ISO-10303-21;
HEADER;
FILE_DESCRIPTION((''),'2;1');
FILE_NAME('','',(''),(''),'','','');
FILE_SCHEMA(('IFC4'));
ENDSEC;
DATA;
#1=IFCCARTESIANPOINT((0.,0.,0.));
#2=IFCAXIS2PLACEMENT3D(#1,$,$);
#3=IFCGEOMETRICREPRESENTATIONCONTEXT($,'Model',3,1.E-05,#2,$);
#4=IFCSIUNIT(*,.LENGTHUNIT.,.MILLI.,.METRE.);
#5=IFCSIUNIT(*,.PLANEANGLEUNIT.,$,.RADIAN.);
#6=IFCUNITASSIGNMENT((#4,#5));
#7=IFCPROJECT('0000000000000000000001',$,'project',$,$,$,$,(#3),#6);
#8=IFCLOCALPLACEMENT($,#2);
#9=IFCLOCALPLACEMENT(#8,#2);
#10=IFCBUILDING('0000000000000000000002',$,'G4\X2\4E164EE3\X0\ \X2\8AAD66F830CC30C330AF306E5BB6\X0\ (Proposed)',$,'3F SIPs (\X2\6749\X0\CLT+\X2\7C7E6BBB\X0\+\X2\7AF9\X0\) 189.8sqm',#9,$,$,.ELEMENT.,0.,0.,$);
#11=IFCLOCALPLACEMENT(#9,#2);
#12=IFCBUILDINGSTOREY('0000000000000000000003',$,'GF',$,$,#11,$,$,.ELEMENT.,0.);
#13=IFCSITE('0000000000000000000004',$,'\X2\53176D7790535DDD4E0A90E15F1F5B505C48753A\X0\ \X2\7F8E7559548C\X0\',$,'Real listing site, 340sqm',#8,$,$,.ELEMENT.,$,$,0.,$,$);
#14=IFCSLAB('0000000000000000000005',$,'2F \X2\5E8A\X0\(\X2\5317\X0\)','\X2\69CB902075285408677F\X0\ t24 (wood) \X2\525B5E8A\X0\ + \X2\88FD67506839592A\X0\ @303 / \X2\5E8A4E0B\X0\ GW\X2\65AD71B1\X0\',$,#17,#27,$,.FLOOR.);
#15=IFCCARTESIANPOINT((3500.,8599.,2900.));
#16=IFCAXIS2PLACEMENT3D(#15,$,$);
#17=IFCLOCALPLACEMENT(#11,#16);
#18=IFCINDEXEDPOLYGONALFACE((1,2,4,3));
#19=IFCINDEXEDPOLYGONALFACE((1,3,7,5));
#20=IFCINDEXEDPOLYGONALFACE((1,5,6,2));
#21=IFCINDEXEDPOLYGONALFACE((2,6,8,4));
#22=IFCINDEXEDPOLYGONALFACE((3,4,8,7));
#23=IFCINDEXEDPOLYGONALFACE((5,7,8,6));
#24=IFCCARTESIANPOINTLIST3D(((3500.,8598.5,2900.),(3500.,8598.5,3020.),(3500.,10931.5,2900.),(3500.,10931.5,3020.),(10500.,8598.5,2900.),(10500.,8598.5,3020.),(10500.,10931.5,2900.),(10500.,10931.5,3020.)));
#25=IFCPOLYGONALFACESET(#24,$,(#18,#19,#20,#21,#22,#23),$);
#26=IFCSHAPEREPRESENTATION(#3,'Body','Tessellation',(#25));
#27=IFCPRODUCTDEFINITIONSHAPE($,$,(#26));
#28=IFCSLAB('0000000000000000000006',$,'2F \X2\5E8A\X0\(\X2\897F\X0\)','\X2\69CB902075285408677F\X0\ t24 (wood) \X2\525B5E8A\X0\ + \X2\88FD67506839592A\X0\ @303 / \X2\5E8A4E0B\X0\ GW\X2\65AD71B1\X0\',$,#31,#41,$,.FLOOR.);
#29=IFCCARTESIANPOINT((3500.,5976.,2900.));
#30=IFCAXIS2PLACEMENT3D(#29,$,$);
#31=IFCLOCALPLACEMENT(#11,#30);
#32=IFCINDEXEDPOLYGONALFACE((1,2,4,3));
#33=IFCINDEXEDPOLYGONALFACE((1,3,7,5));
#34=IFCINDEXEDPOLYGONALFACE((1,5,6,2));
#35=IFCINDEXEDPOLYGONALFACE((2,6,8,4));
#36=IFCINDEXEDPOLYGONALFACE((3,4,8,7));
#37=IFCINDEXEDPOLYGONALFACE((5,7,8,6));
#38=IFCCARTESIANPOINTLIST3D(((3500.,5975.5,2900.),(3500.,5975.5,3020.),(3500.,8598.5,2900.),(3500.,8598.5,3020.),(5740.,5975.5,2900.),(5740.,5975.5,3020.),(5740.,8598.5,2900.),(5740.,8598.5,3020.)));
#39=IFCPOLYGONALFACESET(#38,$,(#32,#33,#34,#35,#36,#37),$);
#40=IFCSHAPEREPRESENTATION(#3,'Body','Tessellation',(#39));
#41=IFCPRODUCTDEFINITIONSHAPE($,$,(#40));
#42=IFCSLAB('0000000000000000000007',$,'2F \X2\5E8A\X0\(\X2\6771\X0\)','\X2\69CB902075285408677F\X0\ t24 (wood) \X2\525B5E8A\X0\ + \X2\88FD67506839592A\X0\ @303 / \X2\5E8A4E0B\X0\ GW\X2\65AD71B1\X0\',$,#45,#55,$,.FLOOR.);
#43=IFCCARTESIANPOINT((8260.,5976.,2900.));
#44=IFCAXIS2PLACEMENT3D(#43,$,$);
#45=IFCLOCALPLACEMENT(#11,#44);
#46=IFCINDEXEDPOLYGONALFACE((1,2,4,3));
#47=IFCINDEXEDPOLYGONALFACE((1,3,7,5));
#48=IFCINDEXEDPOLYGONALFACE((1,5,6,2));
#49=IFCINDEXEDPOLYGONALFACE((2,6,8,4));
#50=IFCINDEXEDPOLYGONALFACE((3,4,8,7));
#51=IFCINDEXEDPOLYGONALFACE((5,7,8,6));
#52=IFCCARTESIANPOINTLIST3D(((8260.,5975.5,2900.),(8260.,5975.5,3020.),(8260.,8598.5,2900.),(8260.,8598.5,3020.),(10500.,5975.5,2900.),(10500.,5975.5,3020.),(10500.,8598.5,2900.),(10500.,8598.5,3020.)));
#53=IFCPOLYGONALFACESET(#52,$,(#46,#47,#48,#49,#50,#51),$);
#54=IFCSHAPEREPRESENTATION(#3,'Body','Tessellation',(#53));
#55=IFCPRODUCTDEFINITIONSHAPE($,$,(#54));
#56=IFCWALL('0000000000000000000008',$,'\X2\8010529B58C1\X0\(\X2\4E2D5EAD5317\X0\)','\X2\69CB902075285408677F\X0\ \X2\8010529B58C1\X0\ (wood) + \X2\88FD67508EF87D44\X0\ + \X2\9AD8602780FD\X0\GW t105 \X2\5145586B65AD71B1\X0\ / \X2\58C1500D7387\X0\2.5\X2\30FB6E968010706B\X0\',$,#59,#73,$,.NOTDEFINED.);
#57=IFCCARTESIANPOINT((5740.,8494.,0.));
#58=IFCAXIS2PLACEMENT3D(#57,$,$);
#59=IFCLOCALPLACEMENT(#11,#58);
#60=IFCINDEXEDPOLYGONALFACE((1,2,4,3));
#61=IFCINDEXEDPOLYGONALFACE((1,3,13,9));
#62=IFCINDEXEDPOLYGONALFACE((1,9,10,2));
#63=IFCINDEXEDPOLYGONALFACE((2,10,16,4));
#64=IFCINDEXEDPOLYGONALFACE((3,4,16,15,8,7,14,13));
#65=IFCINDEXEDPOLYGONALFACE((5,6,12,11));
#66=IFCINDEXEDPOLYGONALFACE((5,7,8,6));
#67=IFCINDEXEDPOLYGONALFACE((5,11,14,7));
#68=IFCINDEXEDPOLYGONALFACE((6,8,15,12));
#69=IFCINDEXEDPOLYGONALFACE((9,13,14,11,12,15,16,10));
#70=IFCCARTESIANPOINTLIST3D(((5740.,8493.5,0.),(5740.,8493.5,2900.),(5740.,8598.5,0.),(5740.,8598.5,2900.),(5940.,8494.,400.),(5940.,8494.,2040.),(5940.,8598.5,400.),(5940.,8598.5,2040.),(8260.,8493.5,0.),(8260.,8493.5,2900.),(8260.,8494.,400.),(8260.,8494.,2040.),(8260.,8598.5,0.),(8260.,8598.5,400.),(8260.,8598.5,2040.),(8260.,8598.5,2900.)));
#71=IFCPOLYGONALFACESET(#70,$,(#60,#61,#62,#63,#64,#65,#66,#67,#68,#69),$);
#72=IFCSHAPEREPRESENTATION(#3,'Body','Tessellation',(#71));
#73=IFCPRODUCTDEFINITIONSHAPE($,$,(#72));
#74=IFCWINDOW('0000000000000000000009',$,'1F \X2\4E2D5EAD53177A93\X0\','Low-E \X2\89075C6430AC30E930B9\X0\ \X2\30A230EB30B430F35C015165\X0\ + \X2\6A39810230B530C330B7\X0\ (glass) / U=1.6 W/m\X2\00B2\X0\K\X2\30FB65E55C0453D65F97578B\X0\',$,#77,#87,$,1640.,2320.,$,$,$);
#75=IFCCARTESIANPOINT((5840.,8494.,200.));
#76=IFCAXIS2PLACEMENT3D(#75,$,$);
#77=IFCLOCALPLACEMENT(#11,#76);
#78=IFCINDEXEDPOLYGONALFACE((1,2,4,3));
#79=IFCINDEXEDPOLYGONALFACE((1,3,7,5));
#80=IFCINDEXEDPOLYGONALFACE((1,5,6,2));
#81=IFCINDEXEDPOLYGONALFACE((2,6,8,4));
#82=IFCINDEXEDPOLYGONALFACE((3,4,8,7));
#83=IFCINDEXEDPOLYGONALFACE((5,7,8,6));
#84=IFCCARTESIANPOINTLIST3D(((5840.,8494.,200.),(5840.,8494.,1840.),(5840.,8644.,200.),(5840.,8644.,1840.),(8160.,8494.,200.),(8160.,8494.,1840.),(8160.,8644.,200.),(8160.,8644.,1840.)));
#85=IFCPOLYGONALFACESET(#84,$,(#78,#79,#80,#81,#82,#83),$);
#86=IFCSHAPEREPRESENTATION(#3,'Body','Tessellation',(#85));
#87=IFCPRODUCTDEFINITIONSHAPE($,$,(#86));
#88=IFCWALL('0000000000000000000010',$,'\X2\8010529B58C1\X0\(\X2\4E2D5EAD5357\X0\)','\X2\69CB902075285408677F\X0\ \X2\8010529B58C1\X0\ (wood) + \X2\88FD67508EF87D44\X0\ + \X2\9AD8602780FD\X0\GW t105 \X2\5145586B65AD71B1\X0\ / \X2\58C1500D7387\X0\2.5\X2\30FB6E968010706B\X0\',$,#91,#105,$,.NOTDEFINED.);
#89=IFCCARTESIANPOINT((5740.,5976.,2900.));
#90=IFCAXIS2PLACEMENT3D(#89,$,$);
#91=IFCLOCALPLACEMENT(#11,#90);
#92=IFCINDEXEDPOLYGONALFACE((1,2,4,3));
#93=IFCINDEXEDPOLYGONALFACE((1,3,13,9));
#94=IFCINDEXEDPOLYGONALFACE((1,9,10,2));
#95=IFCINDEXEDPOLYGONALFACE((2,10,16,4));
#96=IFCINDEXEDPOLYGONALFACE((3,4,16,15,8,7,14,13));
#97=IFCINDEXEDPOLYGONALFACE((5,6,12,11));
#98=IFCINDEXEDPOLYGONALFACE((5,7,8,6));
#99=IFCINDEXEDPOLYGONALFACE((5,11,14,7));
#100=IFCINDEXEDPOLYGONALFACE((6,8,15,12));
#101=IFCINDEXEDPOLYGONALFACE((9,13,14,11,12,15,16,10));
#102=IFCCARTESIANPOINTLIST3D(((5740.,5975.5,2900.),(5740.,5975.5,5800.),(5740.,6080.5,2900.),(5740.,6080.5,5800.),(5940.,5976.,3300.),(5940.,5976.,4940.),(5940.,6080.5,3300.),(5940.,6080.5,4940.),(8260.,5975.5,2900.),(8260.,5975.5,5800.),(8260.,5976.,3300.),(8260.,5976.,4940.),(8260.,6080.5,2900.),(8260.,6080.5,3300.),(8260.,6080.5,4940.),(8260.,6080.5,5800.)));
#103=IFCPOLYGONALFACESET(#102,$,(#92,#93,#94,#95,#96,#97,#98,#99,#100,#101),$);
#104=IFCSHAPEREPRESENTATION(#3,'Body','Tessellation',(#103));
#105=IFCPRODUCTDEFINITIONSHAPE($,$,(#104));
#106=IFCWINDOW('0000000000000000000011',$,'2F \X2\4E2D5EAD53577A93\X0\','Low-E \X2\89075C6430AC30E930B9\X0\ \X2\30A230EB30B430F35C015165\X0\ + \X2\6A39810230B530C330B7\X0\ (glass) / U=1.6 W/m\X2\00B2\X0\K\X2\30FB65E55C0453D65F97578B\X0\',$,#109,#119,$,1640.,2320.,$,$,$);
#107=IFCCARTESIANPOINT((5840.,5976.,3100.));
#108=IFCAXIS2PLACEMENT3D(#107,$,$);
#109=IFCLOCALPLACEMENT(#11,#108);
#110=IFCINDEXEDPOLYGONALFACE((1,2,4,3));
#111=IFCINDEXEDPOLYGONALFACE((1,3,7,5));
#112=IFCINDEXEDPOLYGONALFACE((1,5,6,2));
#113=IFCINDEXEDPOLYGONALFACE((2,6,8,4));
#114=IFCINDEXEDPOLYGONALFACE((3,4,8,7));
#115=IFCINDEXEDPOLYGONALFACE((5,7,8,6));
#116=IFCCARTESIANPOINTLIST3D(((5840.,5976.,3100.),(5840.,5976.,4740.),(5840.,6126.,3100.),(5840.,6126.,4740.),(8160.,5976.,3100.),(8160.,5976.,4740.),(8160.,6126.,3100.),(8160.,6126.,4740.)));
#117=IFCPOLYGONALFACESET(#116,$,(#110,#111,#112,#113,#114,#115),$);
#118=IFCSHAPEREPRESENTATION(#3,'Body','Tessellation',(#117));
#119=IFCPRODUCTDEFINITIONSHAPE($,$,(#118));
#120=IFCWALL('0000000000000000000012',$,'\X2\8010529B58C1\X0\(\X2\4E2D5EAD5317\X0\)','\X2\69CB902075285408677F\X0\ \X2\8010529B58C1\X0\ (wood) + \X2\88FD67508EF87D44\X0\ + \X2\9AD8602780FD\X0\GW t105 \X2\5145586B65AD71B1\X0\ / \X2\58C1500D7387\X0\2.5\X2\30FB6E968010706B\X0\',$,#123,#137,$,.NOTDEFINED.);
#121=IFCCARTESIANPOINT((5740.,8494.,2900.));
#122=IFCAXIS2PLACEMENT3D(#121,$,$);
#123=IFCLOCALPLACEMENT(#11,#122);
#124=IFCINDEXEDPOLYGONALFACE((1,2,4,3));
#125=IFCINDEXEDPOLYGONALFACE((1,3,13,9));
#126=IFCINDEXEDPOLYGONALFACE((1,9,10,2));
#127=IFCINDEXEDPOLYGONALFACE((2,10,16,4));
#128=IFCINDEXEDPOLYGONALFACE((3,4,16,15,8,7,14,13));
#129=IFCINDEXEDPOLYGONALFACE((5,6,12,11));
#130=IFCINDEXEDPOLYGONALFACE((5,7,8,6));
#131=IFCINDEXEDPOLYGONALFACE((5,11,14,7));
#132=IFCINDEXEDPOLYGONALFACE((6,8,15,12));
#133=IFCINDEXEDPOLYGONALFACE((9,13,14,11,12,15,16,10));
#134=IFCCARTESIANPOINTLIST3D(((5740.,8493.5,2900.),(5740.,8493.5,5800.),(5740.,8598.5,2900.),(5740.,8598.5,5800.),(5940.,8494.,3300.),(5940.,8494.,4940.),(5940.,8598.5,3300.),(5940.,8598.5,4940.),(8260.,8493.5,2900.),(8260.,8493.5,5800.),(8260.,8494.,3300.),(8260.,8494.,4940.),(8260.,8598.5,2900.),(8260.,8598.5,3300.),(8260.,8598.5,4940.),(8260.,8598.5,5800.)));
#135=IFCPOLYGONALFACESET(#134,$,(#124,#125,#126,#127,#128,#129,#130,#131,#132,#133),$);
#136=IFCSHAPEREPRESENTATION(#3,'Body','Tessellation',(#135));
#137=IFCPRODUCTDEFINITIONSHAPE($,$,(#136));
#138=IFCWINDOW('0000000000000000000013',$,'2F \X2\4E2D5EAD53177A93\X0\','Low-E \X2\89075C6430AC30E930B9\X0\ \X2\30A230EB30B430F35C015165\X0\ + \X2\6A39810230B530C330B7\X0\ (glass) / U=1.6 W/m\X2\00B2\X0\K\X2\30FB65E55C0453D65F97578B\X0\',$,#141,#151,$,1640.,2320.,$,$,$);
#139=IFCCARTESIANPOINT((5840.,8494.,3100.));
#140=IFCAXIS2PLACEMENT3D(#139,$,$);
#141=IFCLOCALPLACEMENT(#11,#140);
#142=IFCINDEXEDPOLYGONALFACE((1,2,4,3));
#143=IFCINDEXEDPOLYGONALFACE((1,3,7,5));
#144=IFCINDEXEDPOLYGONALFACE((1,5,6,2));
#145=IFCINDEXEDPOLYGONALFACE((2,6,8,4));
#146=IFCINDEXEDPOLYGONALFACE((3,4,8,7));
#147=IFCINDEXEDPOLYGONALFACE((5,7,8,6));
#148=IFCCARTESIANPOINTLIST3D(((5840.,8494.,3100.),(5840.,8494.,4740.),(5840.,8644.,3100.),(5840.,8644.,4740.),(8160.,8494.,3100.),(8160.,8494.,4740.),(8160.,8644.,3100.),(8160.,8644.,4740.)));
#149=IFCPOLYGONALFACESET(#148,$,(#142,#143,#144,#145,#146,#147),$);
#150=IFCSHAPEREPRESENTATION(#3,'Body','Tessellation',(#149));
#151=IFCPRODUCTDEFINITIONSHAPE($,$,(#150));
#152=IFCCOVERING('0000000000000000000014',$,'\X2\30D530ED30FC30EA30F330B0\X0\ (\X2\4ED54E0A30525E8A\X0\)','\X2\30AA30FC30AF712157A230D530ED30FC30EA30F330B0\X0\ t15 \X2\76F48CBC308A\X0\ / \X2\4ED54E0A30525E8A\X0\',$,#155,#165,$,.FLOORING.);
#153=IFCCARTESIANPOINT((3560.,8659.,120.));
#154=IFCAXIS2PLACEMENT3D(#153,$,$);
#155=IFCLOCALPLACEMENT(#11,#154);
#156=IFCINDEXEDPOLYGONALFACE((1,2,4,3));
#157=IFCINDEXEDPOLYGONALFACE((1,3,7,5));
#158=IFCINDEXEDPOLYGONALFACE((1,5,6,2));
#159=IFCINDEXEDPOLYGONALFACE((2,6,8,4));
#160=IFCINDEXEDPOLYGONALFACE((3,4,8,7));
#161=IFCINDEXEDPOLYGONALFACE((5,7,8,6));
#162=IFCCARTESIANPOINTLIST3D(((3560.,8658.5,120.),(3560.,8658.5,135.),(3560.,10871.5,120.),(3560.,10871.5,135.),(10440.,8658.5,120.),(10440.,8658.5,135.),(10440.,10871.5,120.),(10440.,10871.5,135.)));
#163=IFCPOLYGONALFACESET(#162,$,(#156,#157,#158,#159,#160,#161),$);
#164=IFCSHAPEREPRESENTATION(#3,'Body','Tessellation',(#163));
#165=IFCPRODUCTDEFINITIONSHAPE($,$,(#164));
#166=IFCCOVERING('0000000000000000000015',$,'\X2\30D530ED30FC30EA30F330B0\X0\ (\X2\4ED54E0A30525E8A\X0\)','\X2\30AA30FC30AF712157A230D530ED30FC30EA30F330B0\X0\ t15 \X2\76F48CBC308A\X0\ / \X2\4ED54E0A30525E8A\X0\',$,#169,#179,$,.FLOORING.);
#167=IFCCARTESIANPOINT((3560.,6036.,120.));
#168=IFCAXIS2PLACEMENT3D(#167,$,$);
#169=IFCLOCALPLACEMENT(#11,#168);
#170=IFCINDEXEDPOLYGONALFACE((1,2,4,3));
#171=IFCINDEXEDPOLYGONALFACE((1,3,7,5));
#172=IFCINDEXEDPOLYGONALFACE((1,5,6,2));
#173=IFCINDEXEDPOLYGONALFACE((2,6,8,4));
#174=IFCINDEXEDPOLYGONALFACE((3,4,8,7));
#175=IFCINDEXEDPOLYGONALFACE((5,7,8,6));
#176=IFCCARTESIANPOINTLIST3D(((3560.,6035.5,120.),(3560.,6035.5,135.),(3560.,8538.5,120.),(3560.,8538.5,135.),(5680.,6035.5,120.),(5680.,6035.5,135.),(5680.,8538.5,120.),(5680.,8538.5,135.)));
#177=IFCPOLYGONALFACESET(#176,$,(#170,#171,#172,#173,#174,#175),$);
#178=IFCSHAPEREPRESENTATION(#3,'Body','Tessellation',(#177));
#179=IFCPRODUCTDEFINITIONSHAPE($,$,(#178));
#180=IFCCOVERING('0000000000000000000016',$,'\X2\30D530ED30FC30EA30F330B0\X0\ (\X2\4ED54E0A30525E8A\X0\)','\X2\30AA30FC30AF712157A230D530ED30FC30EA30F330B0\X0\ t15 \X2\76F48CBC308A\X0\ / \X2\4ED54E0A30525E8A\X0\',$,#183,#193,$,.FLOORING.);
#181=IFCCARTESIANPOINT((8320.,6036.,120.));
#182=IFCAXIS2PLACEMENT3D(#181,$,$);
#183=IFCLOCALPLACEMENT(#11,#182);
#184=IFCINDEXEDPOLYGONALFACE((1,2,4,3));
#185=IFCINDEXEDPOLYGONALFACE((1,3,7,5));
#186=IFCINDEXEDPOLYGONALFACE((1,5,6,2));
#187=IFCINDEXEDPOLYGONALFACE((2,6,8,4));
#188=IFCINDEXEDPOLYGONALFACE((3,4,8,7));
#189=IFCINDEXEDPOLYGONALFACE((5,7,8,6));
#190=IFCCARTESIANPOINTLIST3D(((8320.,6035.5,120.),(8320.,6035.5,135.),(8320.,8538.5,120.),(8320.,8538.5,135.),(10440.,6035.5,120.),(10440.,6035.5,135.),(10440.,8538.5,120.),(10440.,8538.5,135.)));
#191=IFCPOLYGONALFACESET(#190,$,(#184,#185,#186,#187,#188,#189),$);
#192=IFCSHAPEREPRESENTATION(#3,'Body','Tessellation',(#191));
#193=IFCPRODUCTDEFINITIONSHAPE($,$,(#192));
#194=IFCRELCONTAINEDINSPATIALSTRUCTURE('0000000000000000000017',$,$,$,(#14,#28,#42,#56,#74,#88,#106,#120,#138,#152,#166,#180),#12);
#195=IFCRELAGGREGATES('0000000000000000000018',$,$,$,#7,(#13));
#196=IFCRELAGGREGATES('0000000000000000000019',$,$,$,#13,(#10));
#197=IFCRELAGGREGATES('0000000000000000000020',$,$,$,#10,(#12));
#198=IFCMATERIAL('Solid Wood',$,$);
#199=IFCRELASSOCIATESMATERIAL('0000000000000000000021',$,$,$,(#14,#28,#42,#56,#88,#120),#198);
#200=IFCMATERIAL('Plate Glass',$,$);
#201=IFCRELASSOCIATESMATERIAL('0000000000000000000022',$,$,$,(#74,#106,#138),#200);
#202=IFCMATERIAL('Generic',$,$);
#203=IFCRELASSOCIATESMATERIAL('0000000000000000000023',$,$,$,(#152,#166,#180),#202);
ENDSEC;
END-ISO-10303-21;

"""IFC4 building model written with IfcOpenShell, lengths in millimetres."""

from ifc_helpers import new_model, si_unit, frame, frame_2d, origin, place, context, project, spatial, rectangle, extrude, material, element, fill, save


model = new_model("IFC4")

# Units and contexts
model_context = context("Model", 3, precision=1e-05, world=origin())
ifc_project = project(units=[si_unit("LENGTHUNIT", "METRE", prefix="MILLI"), si_unit("PLANEANGLEUNIT", "RADIAN")], contexts=[model_context])

# Site, building, storey
site_placement = place(None, origin())
site = spatial("IfcSite", under=ifc_project, at=site_placement, Name="北海道川上郡弟子屈町 美留和", ObjectType="Real listing site, 340sqm", CompositionType="ELEMENT", RefElevation=0.0)
building_placement = place(site_placement, origin())
building = spatial("IfcBuilding", under=site, at=building_placement, Name="G4世代 読書ヌックの家 (Proposed)", ObjectType="3F SIPs (杉CLT+籾殻+竹) 189.8sqm", CompositionType="ELEMENT", ElevationOfRefHeight=0.0, ElevationOfTerrain=0.0)
storey_placement = place(building_placement, origin())
storey = spatial("IfcBuildingStorey", under=building, at=storey_placement, Name="GF", CompositionType="ELEMENT", Elevation=0.0)

# Slabs
ifc_material_1 = material(Name="Solid Wood")
slab_1_placement = place(storey_placement, frame((3500.0, 8599.0, 2900.0)))
element("IfcSlab", 1, at=slab_1_placement, inside=storey, material=ifc_material_1, Name="2F 床(北)", Description="構造用合板 t24 (wood) 剛床 + 製材根太 @303 / 床下 GW断熱", PredefinedType="FLOOR", context=model_context, shape_type="SweptSolid", body=[
    extrude(rectangle(XDim=7000.0, YDim=2333.0, at=frame_2d((3500.0, 1166.0))), frame((3500.0, 8599.0, 2900.0)), (0.0, 0.0, 1.0), 120.0),
])
slab_2_placement = place(storey_placement, frame((3500.0, 5976.0, 2900.0)))
element("IfcSlab", 2, at=slab_2_placement, inside=storey, material=ifc_material_1, Name="2F 床(西)", Description="構造用合板 t24 (wood) 剛床 + 製材根太 @303 / 床下 GW断熱", PredefinedType="FLOOR", context=model_context, shape_type="SweptSolid", body=[
    extrude(rectangle(XDim=2240.0, YDim=2623.0, at=frame_2d((1120.0, 1311.0))), frame((3500.0, 5976.0, 2900.0)), (0.0, 0.0, 1.0), 120.0),
])
slab_3_placement = place(storey_placement, frame((8260.0, 5976.0, 2900.0)))
element("IfcSlab", 3, at=slab_3_placement, inside=storey, material=ifc_material_1, Name="2F 床(東)", Description="構造用合板 t24 (wood) 剛床 + 製材根太 @303 / 床下 GW断熱", PredefinedType="FLOOR", context=model_context, shape_type="SweptSolid", body=[
    extrude(rectangle(XDim=2240.0, YDim=2623.0, at=frame_2d((1120.0, 1311.0))), frame((8260.0, 5976.0, 2900.0)), (0.0, 0.0, 1.0), 120.0),
])

# Wall, opening, window
wall_1_placement = place(storey_placement, frame((5740.0, 8494.0, 0.0)))
wall_1 = element("IfcWall", 4, at=wall_1_placement, inside=storey, material=ifc_material_1, Name="耐力壁(中庭北)", Description="構造用合板 耐力壁 (wood) + 製材軸組 + 高性能GW t105 充填断熱 / 壁倍率2.5・準耐火", PredefinedType="NOTDEFINED", context=model_context, shape_type="SweptSolid", body=[
    extrude(rectangle(XDim=2520.0, YDim=105.0, at=frame_2d((1260.0, 52.0))), frame((5740.0, 8494.0, 0.0)), (0.0, 0.0, 1.0), 2900.0),
])
opening_1_placement = place(storey_placement, frame((5840.0, 8494.0, 200.0)))
opening_1 = element("IfcOpeningElement", 5, at=opening_1_placement, cuts=wall_1, PredefinedType="NOTDEFINED", context=model_context, shape_type="SweptSolid", body=[
    extrude(rectangle(XDim=2320.0, YDim=150.0, at=frame_2d((1160.0, 75.0))), frame((5840.0, 8494.0, 200.0)), (0.0, 0.0, 1.0), 1640.0),
])
ifc_material_2 = material(Name="Plate Glass")
window_1_placement = place(storey_placement, frame((5840.0, 8494.0, 200.0)))
window_1 = element("IfcWindow", 6, at=window_1_placement, inside=storey, material=ifc_material_2, Name="1F 中庭北窓", Description="Low-E 複層ガラス アルゴン封入 + 樹脂サッシ (glass) / U=1.6 W/m²K・日射取得型", OverallHeight=1640.0, OverallWidth=2320.0, context=model_context, shape_type="SweptSolid", body=[
    extrude(rectangle(XDim=2320.0, YDim=150.0, at=frame_2d((1160.0, 75.0))), frame((5840.0, 8494.0, 200.0)), (0.0, 0.0, 1.0), 1640.0),
])
fill(opening_1, window_1)

# Walls, openings, windows
wall_2_placement = place(storey_placement, frame((5740.0, 5976.0, 2900.0)))
wall_2 = element("IfcWall", 7, at=wall_2_placement, inside=storey, material=ifc_material_1, Name="耐力壁(中庭南)", Description="構造用合板 耐力壁 (wood) + 製材軸組 + 高性能GW t105 充填断熱 / 壁倍率2.5・準耐火", PredefinedType="NOTDEFINED", context=model_context, shape_type="SweptSolid", body=[
    extrude(rectangle(XDim=2520.0, YDim=105.0, at=frame_2d((1260.0, 52.0))), frame((5740.0, 5976.0, 2900.0)), (0.0, 0.0, 1.0), 2900.0),
])
opening_2_placement = place(storey_placement, frame((5840.0, 5976.0, 3100.0)))
opening_2 = element("IfcOpeningElement", 8, at=opening_2_placement, cuts=wall_2, PredefinedType="NOTDEFINED", context=model_context, shape_type="SweptSolid", body=[
    extrude(rectangle(XDim=2320.0, YDim=150.0, at=frame_2d((1160.0, 75.0))), frame((5840.0, 5976.0, 3100.0)), (0.0, 0.0, 1.0), 1640.0),
])
window_2_placement = place(storey_placement, frame((5840.0, 5976.0, 3100.0)))
window_2 = element("IfcWindow", 9, at=window_2_placement, inside=storey, material=ifc_material_2, Name="2F 中庭南窓", Description="Low-E 複層ガラス アルゴン封入 + 樹脂サッシ (glass) / U=1.6 W/m²K・日射取得型", OverallHeight=1640.0, OverallWidth=2320.0, context=model_context, shape_type="SweptSolid", body=[
    extrude(rectangle(XDim=2320.0, YDim=150.0, at=frame_2d((1160.0, 75.0))), frame((5840.0, 5976.0, 3100.0)), (0.0, 0.0, 1.0), 1640.0),
])
fill(opening_2, window_2)
wall_3_placement = place(storey_placement, frame((5740.0, 8494.0, 2900.0)))
wall_3 = element("IfcWall", 10, at=wall_3_placement, inside=storey, material=ifc_material_1, Name="耐力壁(中庭北)", Description="構造用合板 耐力壁 (wood) + 製材軸組 + 高性能GW t105 充填断熱 / 壁倍率2.5・準耐火", PredefinedType="NOTDEFINED", context=model_context, shape_type="SweptSolid", body=[
    extrude(rectangle(XDim=2520.0, YDim=105.0, at=frame_2d((1260.0, 52.0))), frame((5740.0, 8494.0, 2900.0)), (0.0, 0.0, 1.0), 2900.0),
])
opening_3_placement = place(storey_placement, frame((5840.0, 8494.0, 3100.0)))
opening_3 = element("IfcOpeningElement", 11, at=opening_3_placement, cuts=wall_3, PredefinedType="NOTDEFINED", context=model_context, shape_type="SweptSolid", body=[
    extrude(rectangle(XDim=2320.0, YDim=150.0, at=frame_2d((1160.0, 75.0))), frame((5840.0, 8494.0, 3100.0)), (0.0, 0.0, 1.0), 1640.0),
])
window_3_placement = place(storey_placement, frame((5840.0, 8494.0, 3100.0)))
window_3 = element("IfcWindow", 12, at=window_3_placement, inside=storey, material=ifc_material_2, Name="2F 中庭北窓", Description="Low-E 複層ガラス アルゴン封入 + 樹脂サッシ (glass) / U=1.6 W/m²K・日射取得型", OverallHeight=1640.0, OverallWidth=2320.0, context=model_context, shape_type="SweptSolid", body=[
    extrude(rectangle(XDim=2320.0, YDim=150.0, at=frame_2d((1160.0, 75.0))), frame((5840.0, 8494.0, 3100.0)), (0.0, 0.0, 1.0), 1640.0),
])
fill(opening_3, window_3)

# Coverings
ifc_material_3 = material(Name="Generic")
covering_1_placement = place(storey_placement, frame((3560.0, 8659.0, 120.0)))
element("IfcCovering", 13, at=covering_1_placement, inside=storey, material=ifc_material_3, Name="フローリング (仕上げ床)", Description="オーク無垢フローリング t15 直貼り / 仕上げ床", PredefinedType="FLOORING", context=model_context, shape_type="SweptSolid", body=[
    extrude(rectangle(XDim=6880.0, YDim=2213.0, at=frame_2d((3440.0, 1106.0))), frame((3560.0, 8659.0, 120.0)), (0.0, 0.0, 1.0), 15.0),
])
covering_2_placement = place(storey_placement, frame((3560.0, 6036.0, 120.0)))
element("IfcCovering", 14, at=covering_2_placement, inside=storey, material=ifc_material_3, Name="フローリング (仕上げ床)", Description="オーク無垢フローリング t15 直貼り / 仕上げ床", PredefinedType="FLOORING", context=model_context, shape_type="SweptSolid", body=[
    extrude(rectangle(XDim=2120.0, YDim=2503.0, at=frame_2d((1060.0, 1251.0))), frame((3560.0, 6036.0, 120.0)), (0.0, 0.0, 1.0), 15.0),
])
covering_3_placement = place(storey_placement, frame((8320.0, 6036.0, 120.0)))
element("IfcCovering", 15, at=covering_3_placement, inside=storey, material=ifc_material_3, Name="フローリング (仕上げ床)", Description="オーク無垢フローリング t15 直貼り / 仕上げ床", PredefinedType="FLOORING", context=model_context, shape_type="SweptSolid", body=[
    extrude(rectangle(XDim=2120.0, YDim=2503.0, at=frame_2d((1060.0, 1251.0))), frame((8320.0, 6036.0, 120.0)), (0.0, 0.0, 1.0), 15.0),
])

save(model, "model.ifc")
